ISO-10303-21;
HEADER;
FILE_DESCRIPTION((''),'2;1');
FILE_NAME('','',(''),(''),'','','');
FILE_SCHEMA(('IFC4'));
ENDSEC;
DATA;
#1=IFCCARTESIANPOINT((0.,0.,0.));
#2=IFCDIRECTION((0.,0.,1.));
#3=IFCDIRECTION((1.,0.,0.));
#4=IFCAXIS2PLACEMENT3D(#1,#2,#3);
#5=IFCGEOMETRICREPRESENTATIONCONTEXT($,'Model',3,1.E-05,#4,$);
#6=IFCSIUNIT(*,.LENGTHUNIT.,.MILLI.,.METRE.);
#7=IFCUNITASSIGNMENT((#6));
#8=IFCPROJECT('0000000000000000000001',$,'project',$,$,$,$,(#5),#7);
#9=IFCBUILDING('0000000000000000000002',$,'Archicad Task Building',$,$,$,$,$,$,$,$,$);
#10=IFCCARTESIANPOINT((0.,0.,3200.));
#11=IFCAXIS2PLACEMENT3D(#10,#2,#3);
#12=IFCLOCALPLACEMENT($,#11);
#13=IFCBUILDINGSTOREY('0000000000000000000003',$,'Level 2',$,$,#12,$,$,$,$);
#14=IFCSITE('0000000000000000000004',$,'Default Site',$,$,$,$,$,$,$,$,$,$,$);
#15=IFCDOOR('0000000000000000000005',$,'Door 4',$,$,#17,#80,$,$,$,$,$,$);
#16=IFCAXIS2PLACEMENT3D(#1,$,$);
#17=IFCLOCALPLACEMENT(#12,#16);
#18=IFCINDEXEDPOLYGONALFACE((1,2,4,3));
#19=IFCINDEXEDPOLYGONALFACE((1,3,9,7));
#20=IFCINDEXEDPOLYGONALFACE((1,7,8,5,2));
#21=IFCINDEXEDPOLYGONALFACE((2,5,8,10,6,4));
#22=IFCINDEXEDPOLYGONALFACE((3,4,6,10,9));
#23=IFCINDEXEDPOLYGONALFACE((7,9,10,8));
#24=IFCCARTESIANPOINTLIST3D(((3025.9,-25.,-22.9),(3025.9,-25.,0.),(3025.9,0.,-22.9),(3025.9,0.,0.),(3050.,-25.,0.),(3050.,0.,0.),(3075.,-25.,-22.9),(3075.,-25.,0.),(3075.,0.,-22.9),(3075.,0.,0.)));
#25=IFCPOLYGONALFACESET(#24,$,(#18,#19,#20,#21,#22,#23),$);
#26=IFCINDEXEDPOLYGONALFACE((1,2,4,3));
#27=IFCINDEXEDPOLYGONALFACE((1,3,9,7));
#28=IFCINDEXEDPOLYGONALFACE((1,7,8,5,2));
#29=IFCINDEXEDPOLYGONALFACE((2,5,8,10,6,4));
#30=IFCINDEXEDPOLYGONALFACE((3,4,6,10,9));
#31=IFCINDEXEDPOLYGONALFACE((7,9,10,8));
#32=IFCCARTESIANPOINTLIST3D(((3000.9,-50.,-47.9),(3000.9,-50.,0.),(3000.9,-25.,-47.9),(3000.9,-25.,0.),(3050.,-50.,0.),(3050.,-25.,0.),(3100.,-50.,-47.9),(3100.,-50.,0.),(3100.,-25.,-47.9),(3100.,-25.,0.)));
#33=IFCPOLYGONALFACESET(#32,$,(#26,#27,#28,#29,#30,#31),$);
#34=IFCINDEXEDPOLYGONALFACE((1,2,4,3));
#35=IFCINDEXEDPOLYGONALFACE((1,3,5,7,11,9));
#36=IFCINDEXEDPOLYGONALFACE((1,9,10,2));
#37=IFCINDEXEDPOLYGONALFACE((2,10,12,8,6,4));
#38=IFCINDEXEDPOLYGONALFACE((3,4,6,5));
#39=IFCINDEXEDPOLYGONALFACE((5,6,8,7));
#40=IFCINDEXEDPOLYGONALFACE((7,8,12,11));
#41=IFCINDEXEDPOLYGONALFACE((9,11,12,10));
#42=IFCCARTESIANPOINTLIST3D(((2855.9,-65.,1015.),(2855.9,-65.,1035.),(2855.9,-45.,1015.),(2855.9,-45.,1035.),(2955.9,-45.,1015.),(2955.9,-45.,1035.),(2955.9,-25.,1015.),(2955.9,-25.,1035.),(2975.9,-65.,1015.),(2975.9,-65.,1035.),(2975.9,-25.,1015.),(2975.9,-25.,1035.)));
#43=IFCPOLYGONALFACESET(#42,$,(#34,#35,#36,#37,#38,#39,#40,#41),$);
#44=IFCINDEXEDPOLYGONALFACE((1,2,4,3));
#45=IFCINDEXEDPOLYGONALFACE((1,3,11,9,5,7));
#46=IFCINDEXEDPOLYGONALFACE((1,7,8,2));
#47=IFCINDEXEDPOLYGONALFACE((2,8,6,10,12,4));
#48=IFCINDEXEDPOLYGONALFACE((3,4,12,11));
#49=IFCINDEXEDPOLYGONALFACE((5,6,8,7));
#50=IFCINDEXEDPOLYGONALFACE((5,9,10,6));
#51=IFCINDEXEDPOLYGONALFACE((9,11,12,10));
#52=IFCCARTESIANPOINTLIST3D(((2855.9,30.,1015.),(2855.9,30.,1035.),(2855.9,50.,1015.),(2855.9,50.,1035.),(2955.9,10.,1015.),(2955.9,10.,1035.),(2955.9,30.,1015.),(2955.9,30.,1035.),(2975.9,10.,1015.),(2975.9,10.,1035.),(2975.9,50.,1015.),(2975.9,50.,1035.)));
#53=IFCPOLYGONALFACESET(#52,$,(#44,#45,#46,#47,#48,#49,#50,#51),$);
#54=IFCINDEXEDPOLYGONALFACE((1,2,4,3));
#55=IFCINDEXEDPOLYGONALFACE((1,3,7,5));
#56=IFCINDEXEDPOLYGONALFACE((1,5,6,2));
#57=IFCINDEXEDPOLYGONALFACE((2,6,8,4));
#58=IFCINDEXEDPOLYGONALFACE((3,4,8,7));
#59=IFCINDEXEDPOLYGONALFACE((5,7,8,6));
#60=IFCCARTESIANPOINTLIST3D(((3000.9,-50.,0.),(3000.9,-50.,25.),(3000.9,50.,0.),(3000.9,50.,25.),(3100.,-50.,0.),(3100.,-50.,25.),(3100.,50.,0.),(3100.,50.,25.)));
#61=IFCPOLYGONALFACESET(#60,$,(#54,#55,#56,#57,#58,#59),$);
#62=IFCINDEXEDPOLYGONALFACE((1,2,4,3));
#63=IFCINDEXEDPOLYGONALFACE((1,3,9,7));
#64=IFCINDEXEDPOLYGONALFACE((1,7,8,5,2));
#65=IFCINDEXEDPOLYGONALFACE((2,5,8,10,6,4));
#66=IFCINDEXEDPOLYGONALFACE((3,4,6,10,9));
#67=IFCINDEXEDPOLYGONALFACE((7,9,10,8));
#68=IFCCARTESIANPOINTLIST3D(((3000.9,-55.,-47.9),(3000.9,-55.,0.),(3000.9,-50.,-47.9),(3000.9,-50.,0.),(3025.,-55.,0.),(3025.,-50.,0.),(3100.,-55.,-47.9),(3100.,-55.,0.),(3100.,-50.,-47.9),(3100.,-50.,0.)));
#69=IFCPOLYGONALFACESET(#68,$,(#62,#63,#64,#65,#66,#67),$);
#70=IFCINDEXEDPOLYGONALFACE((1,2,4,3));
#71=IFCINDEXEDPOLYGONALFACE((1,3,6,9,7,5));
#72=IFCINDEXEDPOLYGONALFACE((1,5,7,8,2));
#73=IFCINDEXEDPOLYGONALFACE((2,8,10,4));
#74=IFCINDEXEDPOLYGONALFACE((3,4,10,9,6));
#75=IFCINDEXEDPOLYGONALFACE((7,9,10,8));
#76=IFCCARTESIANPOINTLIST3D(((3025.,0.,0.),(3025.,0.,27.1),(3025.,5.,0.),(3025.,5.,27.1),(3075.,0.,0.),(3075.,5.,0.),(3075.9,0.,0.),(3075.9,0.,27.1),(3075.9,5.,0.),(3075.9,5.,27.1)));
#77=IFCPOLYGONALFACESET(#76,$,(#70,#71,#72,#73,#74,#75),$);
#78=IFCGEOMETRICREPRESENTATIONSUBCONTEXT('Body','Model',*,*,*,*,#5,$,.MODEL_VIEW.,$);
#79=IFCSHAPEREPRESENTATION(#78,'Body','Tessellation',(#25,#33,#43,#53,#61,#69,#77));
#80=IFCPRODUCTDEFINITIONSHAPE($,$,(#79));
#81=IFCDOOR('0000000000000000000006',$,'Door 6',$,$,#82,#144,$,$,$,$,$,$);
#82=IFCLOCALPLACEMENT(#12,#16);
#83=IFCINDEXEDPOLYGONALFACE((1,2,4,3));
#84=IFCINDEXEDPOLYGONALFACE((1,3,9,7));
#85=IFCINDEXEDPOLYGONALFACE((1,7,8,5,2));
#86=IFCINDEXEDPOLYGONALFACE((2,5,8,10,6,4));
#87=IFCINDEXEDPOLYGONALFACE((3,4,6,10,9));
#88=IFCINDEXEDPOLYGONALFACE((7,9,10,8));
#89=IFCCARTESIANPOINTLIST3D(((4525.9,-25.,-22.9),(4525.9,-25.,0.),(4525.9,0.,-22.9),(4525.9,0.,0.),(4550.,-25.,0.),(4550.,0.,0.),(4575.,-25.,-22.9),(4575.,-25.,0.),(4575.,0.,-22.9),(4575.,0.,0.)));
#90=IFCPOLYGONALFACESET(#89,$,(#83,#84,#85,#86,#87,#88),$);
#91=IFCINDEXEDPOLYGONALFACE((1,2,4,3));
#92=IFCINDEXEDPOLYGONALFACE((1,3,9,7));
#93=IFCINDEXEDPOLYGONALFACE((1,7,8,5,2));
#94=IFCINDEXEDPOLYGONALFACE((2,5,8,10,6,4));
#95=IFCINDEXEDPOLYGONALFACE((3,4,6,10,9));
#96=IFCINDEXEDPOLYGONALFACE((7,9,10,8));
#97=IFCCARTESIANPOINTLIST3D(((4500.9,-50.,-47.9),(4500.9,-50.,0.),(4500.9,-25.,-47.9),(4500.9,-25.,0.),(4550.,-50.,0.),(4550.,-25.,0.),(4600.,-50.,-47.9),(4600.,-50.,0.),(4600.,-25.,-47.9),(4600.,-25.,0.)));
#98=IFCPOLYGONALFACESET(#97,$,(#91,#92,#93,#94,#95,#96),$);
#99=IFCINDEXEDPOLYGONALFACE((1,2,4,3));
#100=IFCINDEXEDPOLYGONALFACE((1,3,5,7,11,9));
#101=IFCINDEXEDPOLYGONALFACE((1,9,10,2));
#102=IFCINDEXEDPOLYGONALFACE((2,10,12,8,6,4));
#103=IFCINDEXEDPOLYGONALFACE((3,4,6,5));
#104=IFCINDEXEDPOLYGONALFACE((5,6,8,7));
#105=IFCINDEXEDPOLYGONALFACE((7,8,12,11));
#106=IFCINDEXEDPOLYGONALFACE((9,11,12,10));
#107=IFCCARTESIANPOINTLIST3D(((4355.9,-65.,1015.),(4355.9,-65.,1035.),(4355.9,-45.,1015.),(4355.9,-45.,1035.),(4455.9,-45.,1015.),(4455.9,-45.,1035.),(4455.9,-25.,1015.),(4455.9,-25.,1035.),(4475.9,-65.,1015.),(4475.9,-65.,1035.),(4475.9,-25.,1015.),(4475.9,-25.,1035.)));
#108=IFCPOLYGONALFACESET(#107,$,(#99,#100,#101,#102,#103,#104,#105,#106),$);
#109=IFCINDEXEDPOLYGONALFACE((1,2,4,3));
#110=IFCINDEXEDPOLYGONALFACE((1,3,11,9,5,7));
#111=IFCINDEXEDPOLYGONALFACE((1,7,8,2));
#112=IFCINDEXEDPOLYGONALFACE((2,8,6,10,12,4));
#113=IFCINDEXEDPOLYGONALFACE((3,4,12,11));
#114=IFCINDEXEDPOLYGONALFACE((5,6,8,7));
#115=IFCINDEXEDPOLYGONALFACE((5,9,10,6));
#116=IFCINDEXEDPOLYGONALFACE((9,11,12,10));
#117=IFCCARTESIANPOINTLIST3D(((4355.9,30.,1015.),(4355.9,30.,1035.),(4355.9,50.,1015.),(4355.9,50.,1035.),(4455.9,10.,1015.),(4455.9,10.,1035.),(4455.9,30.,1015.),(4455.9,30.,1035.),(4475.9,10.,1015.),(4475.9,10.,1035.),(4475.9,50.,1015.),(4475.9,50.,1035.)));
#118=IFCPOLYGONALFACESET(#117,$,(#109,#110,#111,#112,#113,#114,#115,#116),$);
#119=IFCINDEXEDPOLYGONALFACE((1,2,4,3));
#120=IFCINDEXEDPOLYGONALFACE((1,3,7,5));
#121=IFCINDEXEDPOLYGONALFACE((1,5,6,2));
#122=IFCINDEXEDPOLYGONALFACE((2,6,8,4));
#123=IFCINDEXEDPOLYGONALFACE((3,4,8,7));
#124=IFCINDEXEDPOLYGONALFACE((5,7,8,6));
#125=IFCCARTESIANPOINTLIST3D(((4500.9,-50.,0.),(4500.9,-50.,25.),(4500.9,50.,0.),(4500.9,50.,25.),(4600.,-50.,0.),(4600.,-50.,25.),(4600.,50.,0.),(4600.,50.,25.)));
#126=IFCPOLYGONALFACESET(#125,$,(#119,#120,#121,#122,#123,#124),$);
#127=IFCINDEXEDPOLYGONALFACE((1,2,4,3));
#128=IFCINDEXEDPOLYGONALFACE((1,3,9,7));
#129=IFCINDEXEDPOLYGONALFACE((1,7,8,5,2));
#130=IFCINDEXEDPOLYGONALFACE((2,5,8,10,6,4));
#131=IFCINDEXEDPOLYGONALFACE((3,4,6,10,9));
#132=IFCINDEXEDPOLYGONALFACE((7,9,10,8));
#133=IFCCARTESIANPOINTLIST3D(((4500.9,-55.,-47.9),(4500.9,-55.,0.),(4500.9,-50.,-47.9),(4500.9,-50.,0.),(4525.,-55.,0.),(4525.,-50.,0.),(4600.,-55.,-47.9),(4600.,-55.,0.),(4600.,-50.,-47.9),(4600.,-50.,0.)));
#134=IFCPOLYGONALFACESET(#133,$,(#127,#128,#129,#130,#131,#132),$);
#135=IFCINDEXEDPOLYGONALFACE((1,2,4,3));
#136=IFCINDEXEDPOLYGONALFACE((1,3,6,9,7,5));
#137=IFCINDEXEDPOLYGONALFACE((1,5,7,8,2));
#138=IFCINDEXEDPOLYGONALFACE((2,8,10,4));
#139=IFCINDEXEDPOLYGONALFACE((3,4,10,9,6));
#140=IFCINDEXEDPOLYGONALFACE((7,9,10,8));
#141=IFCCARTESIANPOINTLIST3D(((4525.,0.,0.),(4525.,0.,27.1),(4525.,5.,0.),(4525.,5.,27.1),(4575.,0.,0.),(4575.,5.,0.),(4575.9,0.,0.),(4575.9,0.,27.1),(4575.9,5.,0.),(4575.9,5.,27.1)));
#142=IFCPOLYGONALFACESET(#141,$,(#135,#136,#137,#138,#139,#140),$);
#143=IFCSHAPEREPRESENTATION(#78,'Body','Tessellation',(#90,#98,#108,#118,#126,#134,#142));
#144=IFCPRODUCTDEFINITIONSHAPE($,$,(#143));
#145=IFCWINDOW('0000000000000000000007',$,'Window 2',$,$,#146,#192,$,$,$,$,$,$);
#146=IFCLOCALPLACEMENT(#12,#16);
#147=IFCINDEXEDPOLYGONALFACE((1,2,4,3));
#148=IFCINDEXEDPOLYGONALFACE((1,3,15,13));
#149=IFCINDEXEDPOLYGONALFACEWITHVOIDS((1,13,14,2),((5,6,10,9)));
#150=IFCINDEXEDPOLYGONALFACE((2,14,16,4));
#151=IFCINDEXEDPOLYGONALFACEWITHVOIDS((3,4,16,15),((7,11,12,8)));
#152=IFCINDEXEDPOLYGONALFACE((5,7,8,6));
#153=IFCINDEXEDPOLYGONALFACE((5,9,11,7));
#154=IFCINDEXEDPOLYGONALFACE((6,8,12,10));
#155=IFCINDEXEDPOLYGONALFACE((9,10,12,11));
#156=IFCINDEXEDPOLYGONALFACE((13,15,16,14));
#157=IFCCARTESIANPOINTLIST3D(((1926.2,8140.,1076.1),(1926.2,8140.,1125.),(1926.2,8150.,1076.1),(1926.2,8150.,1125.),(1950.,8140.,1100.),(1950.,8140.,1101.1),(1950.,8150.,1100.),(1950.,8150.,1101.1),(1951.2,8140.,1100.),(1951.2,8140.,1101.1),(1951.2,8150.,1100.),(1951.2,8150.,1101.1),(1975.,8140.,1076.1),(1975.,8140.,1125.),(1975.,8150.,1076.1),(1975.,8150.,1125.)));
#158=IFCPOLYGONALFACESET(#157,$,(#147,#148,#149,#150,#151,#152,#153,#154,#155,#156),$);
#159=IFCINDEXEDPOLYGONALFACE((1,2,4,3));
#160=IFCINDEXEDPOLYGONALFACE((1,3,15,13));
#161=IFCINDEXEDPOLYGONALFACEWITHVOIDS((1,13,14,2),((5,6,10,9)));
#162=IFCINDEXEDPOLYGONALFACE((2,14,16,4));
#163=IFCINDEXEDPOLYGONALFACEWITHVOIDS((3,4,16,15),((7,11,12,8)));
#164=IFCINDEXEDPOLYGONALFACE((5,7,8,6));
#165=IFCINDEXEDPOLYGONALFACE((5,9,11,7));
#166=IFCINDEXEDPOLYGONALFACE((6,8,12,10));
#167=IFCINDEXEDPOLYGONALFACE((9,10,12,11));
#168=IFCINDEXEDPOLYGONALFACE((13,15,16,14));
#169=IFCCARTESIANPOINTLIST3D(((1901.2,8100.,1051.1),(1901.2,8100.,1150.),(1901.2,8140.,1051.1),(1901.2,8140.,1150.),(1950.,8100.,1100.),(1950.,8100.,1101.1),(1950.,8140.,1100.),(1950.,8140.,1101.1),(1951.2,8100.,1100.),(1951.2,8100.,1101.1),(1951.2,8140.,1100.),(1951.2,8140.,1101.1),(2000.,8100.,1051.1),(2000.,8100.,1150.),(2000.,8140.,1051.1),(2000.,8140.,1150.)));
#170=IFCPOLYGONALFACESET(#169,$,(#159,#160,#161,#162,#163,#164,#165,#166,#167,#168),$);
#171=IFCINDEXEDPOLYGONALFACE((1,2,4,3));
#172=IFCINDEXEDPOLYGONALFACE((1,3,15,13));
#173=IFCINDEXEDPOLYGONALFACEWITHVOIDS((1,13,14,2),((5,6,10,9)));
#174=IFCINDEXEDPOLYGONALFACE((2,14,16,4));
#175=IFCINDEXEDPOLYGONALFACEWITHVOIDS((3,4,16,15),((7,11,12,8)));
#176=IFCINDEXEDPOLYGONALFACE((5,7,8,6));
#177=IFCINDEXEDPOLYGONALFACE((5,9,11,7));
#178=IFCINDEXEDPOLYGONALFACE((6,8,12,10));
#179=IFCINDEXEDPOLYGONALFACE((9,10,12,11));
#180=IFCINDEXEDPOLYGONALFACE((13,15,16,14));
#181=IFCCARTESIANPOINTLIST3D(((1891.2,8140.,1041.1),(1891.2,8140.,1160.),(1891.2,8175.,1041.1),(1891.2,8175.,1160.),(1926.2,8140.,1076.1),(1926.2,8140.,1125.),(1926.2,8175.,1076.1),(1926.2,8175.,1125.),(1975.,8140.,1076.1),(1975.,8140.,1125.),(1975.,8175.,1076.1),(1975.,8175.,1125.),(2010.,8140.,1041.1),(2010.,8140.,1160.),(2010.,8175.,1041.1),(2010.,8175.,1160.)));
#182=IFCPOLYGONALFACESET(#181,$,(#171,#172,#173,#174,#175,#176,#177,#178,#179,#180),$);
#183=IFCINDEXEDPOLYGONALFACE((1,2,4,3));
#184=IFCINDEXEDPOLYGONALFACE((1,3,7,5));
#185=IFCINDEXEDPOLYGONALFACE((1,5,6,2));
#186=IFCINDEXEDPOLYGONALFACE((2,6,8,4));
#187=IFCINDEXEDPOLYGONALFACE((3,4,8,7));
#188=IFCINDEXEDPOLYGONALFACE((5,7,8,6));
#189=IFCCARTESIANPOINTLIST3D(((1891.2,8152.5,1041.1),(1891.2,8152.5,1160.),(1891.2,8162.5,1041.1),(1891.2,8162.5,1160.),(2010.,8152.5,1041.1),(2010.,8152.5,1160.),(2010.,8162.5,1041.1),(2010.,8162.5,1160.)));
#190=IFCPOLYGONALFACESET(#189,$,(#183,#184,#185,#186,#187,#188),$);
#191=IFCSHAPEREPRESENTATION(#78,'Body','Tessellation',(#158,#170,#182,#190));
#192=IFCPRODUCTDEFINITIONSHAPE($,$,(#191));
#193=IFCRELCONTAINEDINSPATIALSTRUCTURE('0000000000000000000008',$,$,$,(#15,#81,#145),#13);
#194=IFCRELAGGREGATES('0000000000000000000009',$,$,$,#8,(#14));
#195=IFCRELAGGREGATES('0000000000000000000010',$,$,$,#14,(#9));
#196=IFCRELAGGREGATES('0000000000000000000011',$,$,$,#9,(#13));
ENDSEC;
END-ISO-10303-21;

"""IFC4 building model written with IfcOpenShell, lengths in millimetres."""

from ifc_helpers import new_model, si_unit, frame, origin_with_axes, place, context, subcontext, project, spatial, line, indexed_curve, outline, extrude, element, save


model = new_model("IFC4")

# Units and contexts
model_context = context("Model", 3, precision=1e-05, world=origin_with_axes())
body_context = subcontext(model_context, "Body", "Model", "MODEL_VIEW")
ifc_project = project(units=[si_unit("LENGTHUNIT", "METRE", prefix="MILLI")], contexts=[model_context])

# Site, building, storey
site = spatial("IfcSite", under=ifc_project, Name="Default Site")
building = spatial("IfcBuilding", under=site, Name="Archicad Task Building")
storey_placement = place(None, frame((0.0, 0.0, 3200.0), z_axis=(0.0, 0.0, 1.0), x_axis=(1.0, 0.0, 0.0)))
storey = spatial("IfcBuildingStorey", under=building, at=storey_placement, Name="Level 2")

# Doors
door_1_placement = place(storey_placement, frame((3050.0, -50.0, 0.0), z_axis=(0.0, 0.0, 1.0), x_axis=(1.0, 0.0, 0.0)))
element("IfcDoor", 1, at=door_1_placement, inside=storey, Name="Door 4", context=body_context, shape_type="SweptSolid", body=[
    extrude(outline(indexed_curve([(0.0, 0.0), (0.0, 2.1), (0.9, 2.1), (0.9, 0.0), (-24.1, 0.0), (-24.1, -22.9), (25.0, -22.9), (25.0, 0.0)], segments=[line(1, 2, 3, 4, 5, 6, 7, 8, 1)])), frame((0.0, 25.0, 0.0), z_axis=(0.0, -1.0, 0.0), x_axis=(1.0, 0.0, 0.0)), (0.0, 0.0, -1.0), 25.0),
    extrude(outline(indexed_curve([(0.0, 0.0), (0.0, 2.1), (0.9, 2.1), (0.9, 0.0), (-49.1, 0.0), (-49.1, -47.9), (50.0, -47.9), (50.0, 0.0)], segments=[line(1, 2, 3, 4, 5, 6, 7, 8, 1)])), frame((0.0, 0.0, 0.0), z_axis=(0.0, -1.0, 0.0), x_axis=(1.0, 0.0, 0.0)), (0.0, 0.0, -1.0), 25.0),
    extrude(outline(indexed_curve([(0.0, 0.0), (-49.1, 0.0), (-49.1, 35.0), (0.0, 35.0)], segments=[line(1, 2, 3, 4, 1)])), frame((25.0, 25.0, 25.0), z_axis=(0.0, 0.0, 1.0), x_axis=(1.0, 0.0, 0.0)), (0.0, 0.0, 1.0), -47.9),
    extrude(outline(indexed_curve([(0.0, 0.0), (0.0, -40.0), (-120.0, -40.0), (-120.0, -20.0), (-20.0, -20.0), (-20.0, 0.0)], segments=[line(1, 2, 3, 4, 5, 6, 1)])), frame((-74.1, 25.0, 1015.0), z_axis=(0.0, 0.0, 1.0), x_axis=(1.0, 0.0, 0.0)), (0.0, 0.0, 1.0), 20.0),
    extrude(outline(indexed_curve([(0.0, 0.0), (0.0, 40.0), (-120.0, 40.0), (-120.0, 20.0), (-20.0, 20.0), (-20.0, 0.0)], segments=[line(1, 2, 3, 4, 5, 6, 1)])), frame((-74.1, 60.0, 1015.0), z_axis=(0.0, 0.0, 1.0), x_axis=(1.0, 0.0, 0.0)), (0.0, 0.0, 1.0), 20.0),
    extrude(outline(indexed_curve([(0.0, 0.0), (-99.1, 0.0), (-99.1, 100.0), (0.0, 100.0)], segments=[line(1, 2, 3, 4, 1)])), frame((50.0, 0.0, 0.0), z_axis=(0.0, 0.0, 1.0), x_axis=(1.0, 0.0, 0.0)), (0.0, 0.0, 1.0), 25.0),
    extrude(outline(indexed_curve([(0.0, 0.0), (0.0, 27.1), (50.9, 27.1), (50.9, 0.0), (-24.1, 0.0), (-24.1, -47.9), (75.0, -47.9), (75.0, 0.0)], segments=[line(1, 2, 3, 4, 5, 6, 7, 8, 1)])), frame((-25.0, -5.0, 0.0), z_axis=(0.0, -1.0, 0.0), x_axis=(1.0, 0.0, 0.0)), (0.0, 0.0, -1.0), 5.0),
    extrude(outline(indexed_curve([(0.0, 0.0), (0.0, 27.1), (50.9, 27.1), (50.9, 0.0), (0.9, 0.0), (0.9, -22.9), (50.0, -22.9), (50.0, 0.0)], segments=[line(1, 2, 3, 4, 5, 6, 7, 8, 1)])), frame((-25.0, 50.0, 0.0), z_axis=(0.0, -1.0, 0.0), x_axis=(1.0, 0.0, 0.0)), (0.0, 0.0, -1.0), 5.0),
])
door_2_placement = place(storey_placement, frame((4550.0, -50.0, 0.0), z_axis=(0.0, 0.0, 1.0), x_axis=(1.0, 0.0, 0.0)))
element("IfcDoor", 2, at=door_2_placement, inside=storey, Name="Door 6", context=body_context, shape_type="SweptSolid", body=[
    extrude(outline(indexed_curve([(0.0, 0.0), (0.0, 2.1), (0.9, 2.1), (0.9, 0.0), (-24.1, 0.0), (-24.1, -22.9), (25.0, -22.9), (25.0, 0.0)], segments=[line(1, 2, 3, 4, 5, 6, 7, 8, 1)])), frame((0.0, 25.0, 0.0), z_axis=(0.0, -1.0, 0.0), x_axis=(1.0, 0.0, 0.0)), (0.0, 0.0, -1.0), 25.0),
    extrude(outline(indexed_curve([(0.0, 0.0), (0.0, 2.1), (0.9, 2.1), (0.9, 0.0), (-49.1, 0.0), (-49.1, -47.9), (50.0, -47.9), (50.0, 0.0)], segments=[line(1, 2, 3, 4, 5, 6, 7, 8, 1)])), frame((0.0, 0.0, 0.0), z_axis=(0.0, -1.0, 0.0), x_axis=(1.0, 0.0, 0.0)), (0.0, 0.0, -1.0), 25.0),
    extrude(outline(indexed_curve([(0.0, 0.0), (-49.1, 0.0), (-49.1, 35.0), (0.0, 35.0)], segments=[line(1, 2, 3, 4, 1)])), frame((25.0, 25.0, 25.0), z_axis=(0.0, 0.0, 1.0), x_axis=(1.0, 0.0, 0.0)), (0.0, 0.0, 1.0), -47.9),
    extrude(outline(indexed_curve([(0.0, 0.0), (0.0, -40.0), (-120.0, -40.0), (-120.0, -20.0), (-20.0, -20.0), (-20.0, 0.0)], segments=[line(1, 2, 3, 4, 5, 6, 1)])), frame((-74.1, 25.0, 1015.0), z_axis=(0.0, 0.0, 1.0), x_axis=(1.0, 0.0, 0.0)), (0.0, 0.0, 1.0), 20.0),
    extrude(outline(indexed_curve([(0.0, 0.0), (0.0, 40.0), (-120.0, 40.0), (-120.0, 20.0), (-20.0, 20.0), (-20.0, 0.0)], segments=[line(1, 2, 3, 4, 5, 6, 1)])), frame((-74.1, 60.0, 1015.0), z_axis=(0.0, 0.0, 1.0), x_axis=(1.0, 0.0, 0.0)), (0.0, 0.0, 1.0), 20.0),
    extrude(outline(indexed_curve([(0.0, 0.0), (-99.1, 0.0), (-99.1, 100.0), (0.0, 100.0)], segments=[line(1, 2, 3, 4, 1)])), frame((50.0, 0.0, 0.0), z_axis=(0.0, 0.0, 1.0), x_axis=(1.0, 0.0, 0.0)), (0.0, 0.0, 1.0), 25.0),
    extrude(outline(indexed_curve([(0.0, 0.0), (0.0, 27.1), (50.9, 27.1), (50.9, 0.0), (-24.1, 0.0), (-24.1, -47.9), (75.0, -47.9), (75.0, 0.0)], segments=[line(1, 2, 3, 4, 5, 6, 7, 8, 1)])), frame((-25.0, -5.0, 0.0), z_axis=(0.0, -1.0, 0.0), x_axis=(1.0, 0.0, 0.0)), (0.0, 0.0, -1.0), 5.0),
    extrude(outline(indexed_curve([(0.0, 0.0), (0.0, 27.1), (50.9, 27.1), (50.9, 0.0), (0.9, 0.0), (0.9, -22.9), (50.0, -22.9), (50.0, 0.0)], segments=[line(1, 2, 3, 4, 5, 6, 7, 8, 1)])), frame((-25.0, 50.0, 0.0), z_axis=(0.0, -1.0, 0.0), x_axis=(1.0, 0.0, 0.0)), (0.0, 0.0, -1.0), 5.0),
])

# Window
for number, where, z_axis, x_axis, name in (
    (3, (1950.0, 8050.0, 1100.0), (0.0, 0.0, 1.0), (1.0, 0.0, 0.0), "Window 2"),
):
    element("IfcWindow", number, at=place(storey_placement, frame(where, z_axis=z_axis, x_axis=x_axis)), inside=storey, Name=name, context=body_context, shape_type="SweptSolid", body=[
        extrude(outline(indexed_curve([(0.0, 0.0), (1.2, 0.0), (1.2, 1.1), (0.0, 1.1)], segments=[line(1, 2, 3, 4, 1)]), holes=[indexed_curve([(25.0, 25.0), (-23.8, 25.0), (-23.8, -23.9), (25.0, -23.9)], segments=[line(1, 2, 3, 4, 1)])]), frame((0.0, 90.0, 0.0), z_axis=(0.0, -1.0, 0.0), x_axis=(1.0, 0.0, 0.0)), (0.0, 0.0, -1.0), 10.0),
        extrude(outline(indexed_curve([(0.0, 0.0), (1.2, 0.0), (1.2, 1.1), (0.0, 1.1)], segments=[line(1, 2, 3, 4, 1)]), holes=[indexed_curve([(50.0, 50.0), (-48.8, 50.0), (-48.8, -48.9), (50.0, -48.9)], segments=[line(1, 2, 3, 4, 1)])]), frame((0.0, 50.0, 0.0), z_axis=(0.0, -1.0, 0.0), x_axis=(1.0, 0.0, 0.0)), (0.0, 0.0, -1.0), 40.0),
        extrude(outline(indexed_curve([(0.0, 0.0), (-48.8, 0.0), (-48.8, -48.9), (0.0, -48.9)], segments=[line(1, 2, 3, 4, 1)]), holes=[indexed_curve([(35.0, 35.0), (-83.8, 35.0), (-83.8, -83.9), (35.0, -83.9)], segments=[line(1, 2, 3, 4, 1)])]), frame((25.0, 90.0, 25.0), z_axis=(0.0, -1.0, 0.0), x_axis=(1.0, 0.0, 0.0)), (0.0, 0.0, -1.0), 35.0),
        extrude(outline(indexed_curve([(35.0, 35.0), (-83.8, 35.0), (-83.8, -83.9), (35.0, -83.9)], segments=[line(1, 2, 3, 4, 1)])), frame((25.0, 102.5, 25.0), z_axis=(0.0, -1.0, 0.0), x_axis=(1.0, 0.0, 0.0)), (0.0, 0.0, -1.0), 10.0),
    ])

save(model, "model.ifc")
